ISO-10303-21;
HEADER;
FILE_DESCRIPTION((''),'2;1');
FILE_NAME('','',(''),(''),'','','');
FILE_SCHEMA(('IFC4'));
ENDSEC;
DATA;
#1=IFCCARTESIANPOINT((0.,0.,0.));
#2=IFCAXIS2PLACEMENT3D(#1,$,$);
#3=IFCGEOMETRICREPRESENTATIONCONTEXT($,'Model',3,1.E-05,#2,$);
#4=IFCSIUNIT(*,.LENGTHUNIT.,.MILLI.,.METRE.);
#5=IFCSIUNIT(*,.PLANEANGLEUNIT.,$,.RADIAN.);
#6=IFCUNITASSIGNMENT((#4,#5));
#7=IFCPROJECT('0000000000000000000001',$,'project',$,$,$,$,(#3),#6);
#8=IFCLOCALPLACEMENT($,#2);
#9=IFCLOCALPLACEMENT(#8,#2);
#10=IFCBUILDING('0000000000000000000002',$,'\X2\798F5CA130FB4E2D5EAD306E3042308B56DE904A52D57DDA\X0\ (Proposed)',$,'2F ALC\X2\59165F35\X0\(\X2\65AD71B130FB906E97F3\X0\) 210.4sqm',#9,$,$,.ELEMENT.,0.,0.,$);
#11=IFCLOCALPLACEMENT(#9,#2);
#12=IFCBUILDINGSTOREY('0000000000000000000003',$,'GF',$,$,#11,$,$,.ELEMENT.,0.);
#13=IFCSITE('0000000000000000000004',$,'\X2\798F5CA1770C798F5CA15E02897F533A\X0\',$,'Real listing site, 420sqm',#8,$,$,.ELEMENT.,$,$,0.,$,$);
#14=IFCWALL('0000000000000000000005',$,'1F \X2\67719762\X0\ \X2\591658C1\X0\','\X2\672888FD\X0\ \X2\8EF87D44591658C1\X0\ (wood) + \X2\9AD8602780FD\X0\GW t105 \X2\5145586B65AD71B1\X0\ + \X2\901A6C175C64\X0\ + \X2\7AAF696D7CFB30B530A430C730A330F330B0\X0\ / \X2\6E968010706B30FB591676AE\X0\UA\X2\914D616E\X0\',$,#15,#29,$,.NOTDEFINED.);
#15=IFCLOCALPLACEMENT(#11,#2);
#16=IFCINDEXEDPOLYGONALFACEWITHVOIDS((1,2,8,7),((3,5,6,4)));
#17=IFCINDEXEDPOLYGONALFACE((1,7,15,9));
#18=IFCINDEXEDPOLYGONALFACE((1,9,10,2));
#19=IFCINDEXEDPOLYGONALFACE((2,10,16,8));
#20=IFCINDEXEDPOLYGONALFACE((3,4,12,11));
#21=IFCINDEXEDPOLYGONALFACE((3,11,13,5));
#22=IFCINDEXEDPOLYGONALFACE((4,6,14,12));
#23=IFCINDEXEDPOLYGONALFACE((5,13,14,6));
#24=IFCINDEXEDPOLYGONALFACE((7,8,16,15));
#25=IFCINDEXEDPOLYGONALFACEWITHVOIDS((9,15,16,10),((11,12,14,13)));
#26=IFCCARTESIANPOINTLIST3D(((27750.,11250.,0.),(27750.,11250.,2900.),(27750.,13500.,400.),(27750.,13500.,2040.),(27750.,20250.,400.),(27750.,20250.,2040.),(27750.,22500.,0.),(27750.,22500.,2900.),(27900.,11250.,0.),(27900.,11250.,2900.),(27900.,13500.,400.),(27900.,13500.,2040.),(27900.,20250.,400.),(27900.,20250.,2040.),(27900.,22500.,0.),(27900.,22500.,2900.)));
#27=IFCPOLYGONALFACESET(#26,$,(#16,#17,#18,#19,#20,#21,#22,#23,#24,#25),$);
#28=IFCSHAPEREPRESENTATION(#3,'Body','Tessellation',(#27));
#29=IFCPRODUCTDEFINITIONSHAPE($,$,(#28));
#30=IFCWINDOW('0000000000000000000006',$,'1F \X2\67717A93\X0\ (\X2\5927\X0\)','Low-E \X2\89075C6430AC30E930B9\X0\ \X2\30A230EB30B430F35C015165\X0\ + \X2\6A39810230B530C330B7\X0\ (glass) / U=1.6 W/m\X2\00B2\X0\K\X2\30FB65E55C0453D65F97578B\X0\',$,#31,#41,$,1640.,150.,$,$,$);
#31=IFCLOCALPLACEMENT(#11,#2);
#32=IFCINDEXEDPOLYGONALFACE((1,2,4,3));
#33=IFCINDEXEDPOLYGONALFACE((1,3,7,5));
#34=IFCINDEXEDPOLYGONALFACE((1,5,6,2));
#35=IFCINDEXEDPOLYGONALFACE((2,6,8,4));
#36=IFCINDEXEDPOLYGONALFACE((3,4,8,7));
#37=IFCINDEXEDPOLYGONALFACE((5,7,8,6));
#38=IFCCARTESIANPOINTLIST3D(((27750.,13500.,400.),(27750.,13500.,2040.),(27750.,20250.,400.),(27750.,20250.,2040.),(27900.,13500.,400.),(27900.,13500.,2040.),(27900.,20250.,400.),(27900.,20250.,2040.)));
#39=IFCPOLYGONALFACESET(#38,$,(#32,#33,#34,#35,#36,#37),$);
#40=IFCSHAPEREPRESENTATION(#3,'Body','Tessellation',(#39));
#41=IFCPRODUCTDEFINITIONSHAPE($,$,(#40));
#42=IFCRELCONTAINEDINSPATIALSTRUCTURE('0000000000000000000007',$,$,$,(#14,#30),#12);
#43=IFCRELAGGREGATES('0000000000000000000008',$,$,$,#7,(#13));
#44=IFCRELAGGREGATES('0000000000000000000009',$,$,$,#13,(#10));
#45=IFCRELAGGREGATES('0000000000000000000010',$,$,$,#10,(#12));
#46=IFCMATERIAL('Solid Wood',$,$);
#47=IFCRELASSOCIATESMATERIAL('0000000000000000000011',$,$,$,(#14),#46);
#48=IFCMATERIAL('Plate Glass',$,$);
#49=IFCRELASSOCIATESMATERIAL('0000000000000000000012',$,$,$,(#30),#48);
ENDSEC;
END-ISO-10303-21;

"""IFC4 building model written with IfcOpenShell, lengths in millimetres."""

from ifc_helpers import new_model, si_unit, frame, frame_2d, origin, place, context, project, spatial, rectangle, extrude, material, element, fill, save


model = new_model("IFC4")

# Units and contexts
model_context = context("Model", 3, precision=1e-05, world=origin())
ifc_project = project(units=[si_unit("LENGTHUNIT", "METRE", prefix="MILLI"), si_unit("PLANEANGLEUNIT", "RADIAN")], contexts=[model_context])

# Site, building, storey
site_placement = place(None, origin())
site = spatial("IfcSite", under=ifc_project, at=site_placement, Name="福岡県福岡市西区", ObjectType="Real listing site, 420sqm", CompositionType="ELEMENT", RefElevation=0.0)
building_placement = place(site_placement, origin())
building = spatial("IfcBuilding", under=site, at=building_placement, Name="福岡・中庭のある回遊動線 (Proposed)", ObjectType="2F ALC外張(断熱・遮音) 210.4sqm", CompositionType="ELEMENT", ElevationOfRefHeight=0.0, ElevationOfTerrain=0.0)
storey_placement = place(building_placement, origin())
storey = spatial("IfcBuildingStorey", under=building, at=storey_placement, Name="GF", CompositionType="ELEMENT", Elevation=0.0)

# Shared definitions
ifc_material_1 = material(Name="Solid Wood")

# Wall, opening, window
wall_1_placement = place(storey_placement, frame((13875.0, 5625.0, 0.0)))
wall_1 = element("IfcWall", 1, at=wall_1_placement, inside=storey, material=ifc_material_1, Name="1F 東面 外壁", Description="木製 軸組外壁 (wood) + 高性能GW t105 充填断熱 + 通気層 + 窯業系サイディング / 準耐火・外皮UA配慮", PredefinedType="NOTDEFINED", context=model_context, shape_type="SweptSolid", body=[
    extrude(rectangle(XDim=150.0, YDim=11250.0, at=frame_2d((75.0, 5625.0))), frame((13875.0, 5625.0, 0.0)), (0.0, 0.0, 1.0), 2900.0),
])
opening_1_placement = place(storey_placement, frame((13875.0, 6750.0, 200.0)))
opening_1 = element("IfcOpeningElement", 2, at=opening_1_placement, cuts=wall_1, PredefinedType="NOTDEFINED", context=model_context, shape_type="SweptSolid", body=[
    extrude(rectangle(XDim=150.0, YDim=6750.0, at=frame_2d((75.0, 3375.0))), frame((13875.0, 6750.0, 200.0)), (0.0, 0.0, 1.0), 1640.0),
])
ifc_material_2 = material(Name="Plate Glass")
window_1_placement = place(storey_placement, frame((13875.0, 6750.0, 200.0)))
window_1 = element("IfcWindow", 3, at=window_1_placement, inside=storey, material=ifc_material_2, Name="1F 東窓 (大)", Description="Low-E 複層ガラス アルゴン封入 + 樹脂サッシ (glass) / U=1.6 W/m²K・日射取得型", OverallHeight=1640.0, OverallWidth=150.0, context=model_context, shape_type="SweptSolid", body=[
    extrude(rectangle(XDim=150.0, YDim=6750.0, at=frame_2d((75.0, 3375.0))), frame((13875.0, 6750.0, 200.0)), (0.0, 0.0, 1.0), 1640.0),
])
fill(opening_1, window_1)

save(model, "model.ifc")
